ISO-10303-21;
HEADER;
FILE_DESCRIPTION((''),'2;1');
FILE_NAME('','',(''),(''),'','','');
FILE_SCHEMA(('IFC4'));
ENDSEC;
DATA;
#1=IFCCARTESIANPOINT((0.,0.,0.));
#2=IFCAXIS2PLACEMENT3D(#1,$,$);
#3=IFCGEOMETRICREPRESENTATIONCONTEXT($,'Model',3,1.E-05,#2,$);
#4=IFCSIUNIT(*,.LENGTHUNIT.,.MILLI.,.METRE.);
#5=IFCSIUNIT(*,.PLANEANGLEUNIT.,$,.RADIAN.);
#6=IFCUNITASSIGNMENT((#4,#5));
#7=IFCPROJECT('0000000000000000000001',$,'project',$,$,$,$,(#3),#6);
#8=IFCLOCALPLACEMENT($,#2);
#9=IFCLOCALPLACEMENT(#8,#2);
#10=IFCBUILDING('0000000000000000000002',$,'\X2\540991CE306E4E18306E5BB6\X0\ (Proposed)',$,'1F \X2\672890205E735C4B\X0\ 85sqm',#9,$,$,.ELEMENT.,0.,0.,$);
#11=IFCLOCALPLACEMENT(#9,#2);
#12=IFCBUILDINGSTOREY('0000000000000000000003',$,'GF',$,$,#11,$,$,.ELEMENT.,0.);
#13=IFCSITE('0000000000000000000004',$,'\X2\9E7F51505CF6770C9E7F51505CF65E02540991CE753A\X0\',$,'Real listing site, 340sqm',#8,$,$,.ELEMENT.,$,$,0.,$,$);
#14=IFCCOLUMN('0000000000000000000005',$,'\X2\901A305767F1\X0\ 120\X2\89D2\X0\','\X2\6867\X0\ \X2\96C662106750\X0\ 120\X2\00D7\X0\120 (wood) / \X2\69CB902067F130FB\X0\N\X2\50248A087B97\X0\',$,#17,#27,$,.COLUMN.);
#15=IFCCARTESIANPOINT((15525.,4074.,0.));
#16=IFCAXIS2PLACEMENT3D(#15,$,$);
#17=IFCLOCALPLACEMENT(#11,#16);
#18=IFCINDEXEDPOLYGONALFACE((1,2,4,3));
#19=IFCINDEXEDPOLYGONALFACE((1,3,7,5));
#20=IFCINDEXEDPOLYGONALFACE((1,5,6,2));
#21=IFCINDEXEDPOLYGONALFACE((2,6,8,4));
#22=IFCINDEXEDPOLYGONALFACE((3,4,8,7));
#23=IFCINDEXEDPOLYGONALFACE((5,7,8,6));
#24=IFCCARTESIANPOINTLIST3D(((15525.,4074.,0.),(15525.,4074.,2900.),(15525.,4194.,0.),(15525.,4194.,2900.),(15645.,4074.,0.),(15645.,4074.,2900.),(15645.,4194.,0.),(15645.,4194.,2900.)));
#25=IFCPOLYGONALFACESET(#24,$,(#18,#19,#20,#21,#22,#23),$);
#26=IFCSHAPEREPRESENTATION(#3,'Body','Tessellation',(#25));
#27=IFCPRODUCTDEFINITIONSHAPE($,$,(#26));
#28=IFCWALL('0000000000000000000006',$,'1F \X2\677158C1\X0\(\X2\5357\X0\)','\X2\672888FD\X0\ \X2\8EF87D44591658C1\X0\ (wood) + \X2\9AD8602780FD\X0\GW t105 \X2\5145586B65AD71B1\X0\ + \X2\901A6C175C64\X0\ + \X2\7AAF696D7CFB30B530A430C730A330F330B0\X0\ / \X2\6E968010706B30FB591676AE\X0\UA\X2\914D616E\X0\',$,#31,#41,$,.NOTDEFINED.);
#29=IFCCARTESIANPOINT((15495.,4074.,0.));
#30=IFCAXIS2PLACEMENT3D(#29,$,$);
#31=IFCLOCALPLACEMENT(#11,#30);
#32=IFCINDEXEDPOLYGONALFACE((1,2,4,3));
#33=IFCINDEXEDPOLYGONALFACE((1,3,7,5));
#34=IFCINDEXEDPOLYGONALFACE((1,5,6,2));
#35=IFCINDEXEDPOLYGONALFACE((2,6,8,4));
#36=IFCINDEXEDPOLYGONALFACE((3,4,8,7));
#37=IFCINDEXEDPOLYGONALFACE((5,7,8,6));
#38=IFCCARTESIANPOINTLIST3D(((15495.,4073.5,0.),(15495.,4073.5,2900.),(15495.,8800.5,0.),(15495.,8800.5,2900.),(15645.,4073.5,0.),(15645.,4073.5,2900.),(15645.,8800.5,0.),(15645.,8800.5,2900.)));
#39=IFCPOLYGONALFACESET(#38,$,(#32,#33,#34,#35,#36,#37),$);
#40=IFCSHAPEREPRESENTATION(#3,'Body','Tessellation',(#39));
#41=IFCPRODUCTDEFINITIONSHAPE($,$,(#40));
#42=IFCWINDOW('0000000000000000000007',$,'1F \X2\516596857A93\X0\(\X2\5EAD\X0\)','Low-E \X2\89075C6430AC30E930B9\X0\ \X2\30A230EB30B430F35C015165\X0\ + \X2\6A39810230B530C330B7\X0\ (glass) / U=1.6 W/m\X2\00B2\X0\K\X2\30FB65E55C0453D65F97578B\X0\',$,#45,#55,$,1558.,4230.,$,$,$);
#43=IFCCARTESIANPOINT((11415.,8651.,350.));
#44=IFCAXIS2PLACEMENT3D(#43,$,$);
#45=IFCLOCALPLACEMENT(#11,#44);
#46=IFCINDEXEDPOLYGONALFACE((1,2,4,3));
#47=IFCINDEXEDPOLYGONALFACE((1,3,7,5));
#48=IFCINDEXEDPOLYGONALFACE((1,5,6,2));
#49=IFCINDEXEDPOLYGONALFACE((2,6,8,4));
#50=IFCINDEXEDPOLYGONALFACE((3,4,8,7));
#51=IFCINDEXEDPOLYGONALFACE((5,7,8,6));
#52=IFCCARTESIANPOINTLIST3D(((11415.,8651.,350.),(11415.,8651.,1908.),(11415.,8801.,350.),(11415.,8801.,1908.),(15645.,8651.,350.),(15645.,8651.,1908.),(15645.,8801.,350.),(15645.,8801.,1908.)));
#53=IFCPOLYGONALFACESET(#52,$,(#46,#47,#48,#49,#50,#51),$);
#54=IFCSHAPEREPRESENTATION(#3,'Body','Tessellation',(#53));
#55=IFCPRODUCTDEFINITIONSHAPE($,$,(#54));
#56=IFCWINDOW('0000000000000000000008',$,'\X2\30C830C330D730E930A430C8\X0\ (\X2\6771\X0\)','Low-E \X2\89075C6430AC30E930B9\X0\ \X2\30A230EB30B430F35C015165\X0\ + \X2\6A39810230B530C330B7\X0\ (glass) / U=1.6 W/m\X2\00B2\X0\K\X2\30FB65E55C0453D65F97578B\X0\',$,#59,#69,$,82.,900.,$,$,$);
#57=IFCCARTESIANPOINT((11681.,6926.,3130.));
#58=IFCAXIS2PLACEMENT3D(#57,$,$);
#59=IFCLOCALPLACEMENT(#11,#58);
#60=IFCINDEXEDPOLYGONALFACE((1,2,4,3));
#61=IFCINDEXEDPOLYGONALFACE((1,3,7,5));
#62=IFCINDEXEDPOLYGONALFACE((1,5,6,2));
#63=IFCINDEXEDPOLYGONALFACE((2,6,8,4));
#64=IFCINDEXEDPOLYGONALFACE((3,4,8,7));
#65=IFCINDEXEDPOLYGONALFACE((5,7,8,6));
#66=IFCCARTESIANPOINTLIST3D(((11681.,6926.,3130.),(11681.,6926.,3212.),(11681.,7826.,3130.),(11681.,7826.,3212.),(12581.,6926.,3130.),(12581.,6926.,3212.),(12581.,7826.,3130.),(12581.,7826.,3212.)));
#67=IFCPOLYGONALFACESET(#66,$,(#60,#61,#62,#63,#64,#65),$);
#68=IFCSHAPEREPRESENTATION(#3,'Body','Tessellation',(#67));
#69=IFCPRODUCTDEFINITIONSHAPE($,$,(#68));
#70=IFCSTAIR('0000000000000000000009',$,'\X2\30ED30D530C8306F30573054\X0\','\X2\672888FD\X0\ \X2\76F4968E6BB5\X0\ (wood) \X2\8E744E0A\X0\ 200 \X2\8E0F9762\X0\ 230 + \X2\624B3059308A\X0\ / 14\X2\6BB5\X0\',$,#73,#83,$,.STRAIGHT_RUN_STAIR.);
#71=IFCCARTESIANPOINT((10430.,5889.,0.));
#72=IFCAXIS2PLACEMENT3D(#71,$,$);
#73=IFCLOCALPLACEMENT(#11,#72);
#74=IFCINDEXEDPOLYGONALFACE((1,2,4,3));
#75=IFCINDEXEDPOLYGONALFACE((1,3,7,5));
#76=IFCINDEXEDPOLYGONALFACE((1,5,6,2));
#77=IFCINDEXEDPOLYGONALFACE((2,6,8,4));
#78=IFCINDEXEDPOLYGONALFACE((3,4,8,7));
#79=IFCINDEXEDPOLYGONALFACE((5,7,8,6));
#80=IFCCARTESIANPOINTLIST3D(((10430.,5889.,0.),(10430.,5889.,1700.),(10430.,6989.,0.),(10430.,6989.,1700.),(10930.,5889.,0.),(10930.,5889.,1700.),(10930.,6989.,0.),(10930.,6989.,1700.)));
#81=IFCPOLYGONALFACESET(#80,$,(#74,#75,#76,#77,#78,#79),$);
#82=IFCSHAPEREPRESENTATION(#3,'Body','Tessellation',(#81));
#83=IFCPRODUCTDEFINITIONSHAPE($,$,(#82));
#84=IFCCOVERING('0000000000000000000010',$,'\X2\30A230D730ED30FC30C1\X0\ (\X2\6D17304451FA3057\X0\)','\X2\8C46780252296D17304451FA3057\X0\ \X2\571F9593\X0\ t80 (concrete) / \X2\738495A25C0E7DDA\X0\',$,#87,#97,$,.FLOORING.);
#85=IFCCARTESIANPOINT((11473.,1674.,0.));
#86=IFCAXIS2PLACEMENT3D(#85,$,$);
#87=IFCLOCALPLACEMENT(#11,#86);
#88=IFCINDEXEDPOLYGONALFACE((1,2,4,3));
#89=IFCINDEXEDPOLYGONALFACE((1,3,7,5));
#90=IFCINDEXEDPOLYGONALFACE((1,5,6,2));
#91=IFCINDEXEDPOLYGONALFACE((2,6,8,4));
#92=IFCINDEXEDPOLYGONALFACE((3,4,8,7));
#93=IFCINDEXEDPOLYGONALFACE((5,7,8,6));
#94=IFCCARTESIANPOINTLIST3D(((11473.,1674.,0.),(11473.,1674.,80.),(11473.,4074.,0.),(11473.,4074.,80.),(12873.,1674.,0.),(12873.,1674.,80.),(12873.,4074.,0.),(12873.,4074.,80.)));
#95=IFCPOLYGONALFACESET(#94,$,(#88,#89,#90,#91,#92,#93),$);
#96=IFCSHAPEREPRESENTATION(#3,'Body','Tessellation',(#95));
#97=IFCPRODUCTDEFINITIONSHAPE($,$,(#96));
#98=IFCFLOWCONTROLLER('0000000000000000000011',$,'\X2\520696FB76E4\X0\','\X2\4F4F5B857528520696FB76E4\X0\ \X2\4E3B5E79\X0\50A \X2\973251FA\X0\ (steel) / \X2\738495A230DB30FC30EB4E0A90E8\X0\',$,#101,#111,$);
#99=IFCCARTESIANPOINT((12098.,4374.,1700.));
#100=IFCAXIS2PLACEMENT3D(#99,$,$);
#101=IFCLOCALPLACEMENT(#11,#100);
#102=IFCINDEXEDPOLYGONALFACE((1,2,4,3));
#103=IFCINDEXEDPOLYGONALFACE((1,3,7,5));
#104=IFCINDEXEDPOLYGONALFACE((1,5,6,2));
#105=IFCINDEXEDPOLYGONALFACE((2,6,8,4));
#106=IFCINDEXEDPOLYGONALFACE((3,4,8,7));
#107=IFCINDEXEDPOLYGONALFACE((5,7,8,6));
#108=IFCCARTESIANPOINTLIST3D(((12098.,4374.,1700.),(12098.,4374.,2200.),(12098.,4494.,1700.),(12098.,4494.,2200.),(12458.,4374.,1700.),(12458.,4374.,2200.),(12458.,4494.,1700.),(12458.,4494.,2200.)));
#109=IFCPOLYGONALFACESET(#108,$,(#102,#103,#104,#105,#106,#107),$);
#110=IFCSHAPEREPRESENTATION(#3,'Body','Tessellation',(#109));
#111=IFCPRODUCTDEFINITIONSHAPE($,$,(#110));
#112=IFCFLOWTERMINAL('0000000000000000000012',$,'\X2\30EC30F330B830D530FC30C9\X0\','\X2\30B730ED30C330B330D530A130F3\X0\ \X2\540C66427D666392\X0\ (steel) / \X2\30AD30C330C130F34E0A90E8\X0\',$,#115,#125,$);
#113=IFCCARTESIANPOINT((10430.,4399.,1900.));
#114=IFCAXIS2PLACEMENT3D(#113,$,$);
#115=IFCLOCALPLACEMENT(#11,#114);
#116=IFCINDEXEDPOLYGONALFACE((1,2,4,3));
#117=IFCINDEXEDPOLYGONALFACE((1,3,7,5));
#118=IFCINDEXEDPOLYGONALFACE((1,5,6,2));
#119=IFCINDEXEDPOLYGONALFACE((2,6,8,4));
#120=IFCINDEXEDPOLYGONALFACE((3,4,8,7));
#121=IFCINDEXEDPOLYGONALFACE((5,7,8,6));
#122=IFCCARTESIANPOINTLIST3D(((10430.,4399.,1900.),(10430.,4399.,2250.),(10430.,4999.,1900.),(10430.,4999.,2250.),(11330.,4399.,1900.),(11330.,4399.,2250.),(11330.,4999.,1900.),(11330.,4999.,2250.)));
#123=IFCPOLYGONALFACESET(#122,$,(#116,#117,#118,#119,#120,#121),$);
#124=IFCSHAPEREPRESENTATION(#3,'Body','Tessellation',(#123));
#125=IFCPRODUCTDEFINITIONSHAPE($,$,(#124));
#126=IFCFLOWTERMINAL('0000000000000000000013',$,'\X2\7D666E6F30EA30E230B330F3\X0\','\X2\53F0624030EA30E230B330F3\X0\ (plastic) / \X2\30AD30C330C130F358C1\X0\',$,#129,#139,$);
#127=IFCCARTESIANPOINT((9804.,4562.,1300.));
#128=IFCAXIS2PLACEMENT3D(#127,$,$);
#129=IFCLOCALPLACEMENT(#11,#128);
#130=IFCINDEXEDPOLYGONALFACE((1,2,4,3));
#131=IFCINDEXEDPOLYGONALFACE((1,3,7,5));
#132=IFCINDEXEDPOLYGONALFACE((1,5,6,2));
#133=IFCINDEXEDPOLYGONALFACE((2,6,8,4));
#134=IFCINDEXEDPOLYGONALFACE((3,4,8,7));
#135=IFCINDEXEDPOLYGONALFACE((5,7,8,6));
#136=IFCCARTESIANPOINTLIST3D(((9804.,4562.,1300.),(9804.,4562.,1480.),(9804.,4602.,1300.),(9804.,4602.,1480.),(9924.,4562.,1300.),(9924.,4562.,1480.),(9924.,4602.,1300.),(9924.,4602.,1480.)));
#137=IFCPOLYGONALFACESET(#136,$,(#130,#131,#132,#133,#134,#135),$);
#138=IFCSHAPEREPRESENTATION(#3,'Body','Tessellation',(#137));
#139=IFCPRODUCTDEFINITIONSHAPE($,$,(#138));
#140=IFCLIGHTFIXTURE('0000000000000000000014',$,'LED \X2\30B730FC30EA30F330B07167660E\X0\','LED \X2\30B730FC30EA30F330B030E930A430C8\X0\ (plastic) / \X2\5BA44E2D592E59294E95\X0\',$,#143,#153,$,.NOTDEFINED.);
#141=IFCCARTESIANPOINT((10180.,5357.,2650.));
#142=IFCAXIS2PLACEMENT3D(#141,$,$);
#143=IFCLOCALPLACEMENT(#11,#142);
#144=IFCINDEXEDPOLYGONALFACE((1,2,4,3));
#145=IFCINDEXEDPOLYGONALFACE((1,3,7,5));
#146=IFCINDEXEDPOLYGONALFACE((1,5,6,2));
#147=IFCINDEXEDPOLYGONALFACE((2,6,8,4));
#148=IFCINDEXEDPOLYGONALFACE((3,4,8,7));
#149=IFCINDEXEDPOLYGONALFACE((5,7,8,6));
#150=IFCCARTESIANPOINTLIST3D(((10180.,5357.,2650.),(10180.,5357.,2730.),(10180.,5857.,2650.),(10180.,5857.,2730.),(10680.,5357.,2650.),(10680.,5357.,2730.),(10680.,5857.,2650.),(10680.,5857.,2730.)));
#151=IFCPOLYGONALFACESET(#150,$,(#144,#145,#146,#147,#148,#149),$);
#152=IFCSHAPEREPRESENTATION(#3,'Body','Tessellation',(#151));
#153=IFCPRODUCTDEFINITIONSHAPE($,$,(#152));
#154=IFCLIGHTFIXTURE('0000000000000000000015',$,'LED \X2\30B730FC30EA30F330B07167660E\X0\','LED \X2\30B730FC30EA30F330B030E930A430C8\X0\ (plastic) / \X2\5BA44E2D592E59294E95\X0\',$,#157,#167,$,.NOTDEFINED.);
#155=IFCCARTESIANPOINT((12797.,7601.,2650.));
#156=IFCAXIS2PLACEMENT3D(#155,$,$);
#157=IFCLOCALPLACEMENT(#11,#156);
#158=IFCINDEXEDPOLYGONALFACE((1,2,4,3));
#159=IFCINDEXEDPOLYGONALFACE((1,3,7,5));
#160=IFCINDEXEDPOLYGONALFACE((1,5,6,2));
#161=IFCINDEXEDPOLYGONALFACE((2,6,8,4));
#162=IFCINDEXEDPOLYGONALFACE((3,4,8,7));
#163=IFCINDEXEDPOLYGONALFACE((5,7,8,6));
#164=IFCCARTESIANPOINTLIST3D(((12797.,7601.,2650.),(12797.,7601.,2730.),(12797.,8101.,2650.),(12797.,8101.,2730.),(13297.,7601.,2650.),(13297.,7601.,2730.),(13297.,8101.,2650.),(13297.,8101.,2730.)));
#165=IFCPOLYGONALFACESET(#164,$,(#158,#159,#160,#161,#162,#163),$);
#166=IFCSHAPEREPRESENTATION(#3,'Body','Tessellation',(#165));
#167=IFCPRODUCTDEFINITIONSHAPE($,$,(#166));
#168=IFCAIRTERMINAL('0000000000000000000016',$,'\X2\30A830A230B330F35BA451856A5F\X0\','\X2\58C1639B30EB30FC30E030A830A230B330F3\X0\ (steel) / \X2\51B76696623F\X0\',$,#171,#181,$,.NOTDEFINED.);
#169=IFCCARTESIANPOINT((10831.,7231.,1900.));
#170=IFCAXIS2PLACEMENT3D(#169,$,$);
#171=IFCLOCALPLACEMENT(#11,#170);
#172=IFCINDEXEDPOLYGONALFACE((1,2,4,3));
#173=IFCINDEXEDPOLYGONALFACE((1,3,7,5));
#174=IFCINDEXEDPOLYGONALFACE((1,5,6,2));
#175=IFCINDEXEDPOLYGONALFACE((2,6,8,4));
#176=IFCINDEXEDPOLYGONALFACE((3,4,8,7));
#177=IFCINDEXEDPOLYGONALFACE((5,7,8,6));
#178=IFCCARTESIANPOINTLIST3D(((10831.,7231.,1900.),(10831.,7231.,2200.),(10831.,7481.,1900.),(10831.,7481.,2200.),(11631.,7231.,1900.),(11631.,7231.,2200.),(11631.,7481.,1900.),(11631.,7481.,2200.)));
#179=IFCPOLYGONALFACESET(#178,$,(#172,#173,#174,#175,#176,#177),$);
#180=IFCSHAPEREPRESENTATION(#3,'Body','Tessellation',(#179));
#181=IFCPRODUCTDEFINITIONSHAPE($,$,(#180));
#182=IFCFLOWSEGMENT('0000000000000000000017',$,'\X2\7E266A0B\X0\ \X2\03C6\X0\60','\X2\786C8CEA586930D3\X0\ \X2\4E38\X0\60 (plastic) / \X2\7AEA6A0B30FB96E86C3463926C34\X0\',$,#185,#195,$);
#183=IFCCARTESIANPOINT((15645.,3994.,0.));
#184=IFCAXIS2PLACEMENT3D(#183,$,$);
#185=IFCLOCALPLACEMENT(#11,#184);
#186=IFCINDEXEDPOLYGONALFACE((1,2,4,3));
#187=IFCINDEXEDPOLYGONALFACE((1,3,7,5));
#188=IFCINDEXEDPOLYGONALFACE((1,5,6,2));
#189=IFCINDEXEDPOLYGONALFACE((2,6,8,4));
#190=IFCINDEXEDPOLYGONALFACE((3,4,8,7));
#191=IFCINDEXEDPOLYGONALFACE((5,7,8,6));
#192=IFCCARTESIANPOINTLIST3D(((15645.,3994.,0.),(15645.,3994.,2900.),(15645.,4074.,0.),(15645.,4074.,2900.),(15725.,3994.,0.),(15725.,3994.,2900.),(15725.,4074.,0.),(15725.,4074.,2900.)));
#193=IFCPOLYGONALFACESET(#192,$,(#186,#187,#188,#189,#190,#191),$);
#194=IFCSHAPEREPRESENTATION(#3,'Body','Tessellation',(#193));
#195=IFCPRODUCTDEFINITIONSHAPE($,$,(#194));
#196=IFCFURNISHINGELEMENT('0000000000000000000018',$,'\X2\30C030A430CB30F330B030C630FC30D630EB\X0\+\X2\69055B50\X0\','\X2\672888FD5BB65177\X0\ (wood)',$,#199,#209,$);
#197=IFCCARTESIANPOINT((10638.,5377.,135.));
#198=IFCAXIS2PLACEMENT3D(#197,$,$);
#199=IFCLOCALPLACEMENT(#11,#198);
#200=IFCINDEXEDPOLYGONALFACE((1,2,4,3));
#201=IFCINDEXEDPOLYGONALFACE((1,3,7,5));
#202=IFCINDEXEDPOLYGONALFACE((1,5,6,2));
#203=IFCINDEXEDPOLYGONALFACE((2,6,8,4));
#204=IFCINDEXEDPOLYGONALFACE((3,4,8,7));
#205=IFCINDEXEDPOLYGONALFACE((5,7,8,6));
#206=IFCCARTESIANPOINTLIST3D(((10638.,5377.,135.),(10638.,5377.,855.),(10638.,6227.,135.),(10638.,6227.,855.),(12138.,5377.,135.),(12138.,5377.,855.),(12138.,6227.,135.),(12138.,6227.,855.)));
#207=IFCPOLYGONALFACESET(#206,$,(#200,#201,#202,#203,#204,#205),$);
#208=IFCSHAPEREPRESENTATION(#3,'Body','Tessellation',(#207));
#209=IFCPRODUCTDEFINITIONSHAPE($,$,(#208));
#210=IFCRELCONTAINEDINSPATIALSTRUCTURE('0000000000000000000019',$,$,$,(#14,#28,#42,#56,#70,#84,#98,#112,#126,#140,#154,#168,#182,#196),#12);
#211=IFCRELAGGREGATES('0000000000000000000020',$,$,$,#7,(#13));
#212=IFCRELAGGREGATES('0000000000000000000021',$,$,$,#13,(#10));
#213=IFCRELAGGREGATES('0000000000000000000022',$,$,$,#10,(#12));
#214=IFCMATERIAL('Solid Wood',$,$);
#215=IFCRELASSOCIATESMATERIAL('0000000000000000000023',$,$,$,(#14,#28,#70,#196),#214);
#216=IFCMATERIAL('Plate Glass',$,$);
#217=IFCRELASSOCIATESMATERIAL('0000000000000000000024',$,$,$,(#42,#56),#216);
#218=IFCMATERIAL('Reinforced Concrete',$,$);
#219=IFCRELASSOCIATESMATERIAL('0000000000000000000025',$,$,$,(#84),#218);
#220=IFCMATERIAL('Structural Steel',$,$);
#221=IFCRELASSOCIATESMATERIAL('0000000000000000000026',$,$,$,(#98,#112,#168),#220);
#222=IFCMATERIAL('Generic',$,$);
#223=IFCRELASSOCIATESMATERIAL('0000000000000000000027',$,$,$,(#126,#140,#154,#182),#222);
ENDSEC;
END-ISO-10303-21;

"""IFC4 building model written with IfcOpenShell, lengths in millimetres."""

from ifc_helpers import new_model, si_unit, frame, frame_2d, origin, place, context, project, spatial, rectangle, extrude, material, element, fill, save


model = new_model("IFC4")

# Units and contexts
model_context = context("Model", 3, precision=1e-05, world=origin())
ifc_project = project(units=[si_unit("LENGTHUNIT", "METRE", prefix="MILLI"), si_unit("PLANEANGLEUNIT", "RADIAN")], contexts=[model_context])

# Site, building, storey
site_placement = place(None, origin())
site = spatial("IfcSite", under=ifc_project, at=site_placement, Name="鹿児島県鹿児島市吉野町", ObjectType="Real listing site, 340sqm", CompositionType="ELEMENT", RefElevation=0.0)
building_placement = place(site_placement, origin())
building = spatial("IfcBuilding", under=site, at=building_placement, Name="吉野の丘の家 (Proposed)", ObjectType="1F 木造平屋 85sqm", CompositionType="ELEMENT", ElevationOfRefHeight=0.0, ElevationOfTerrain=0.0)
storey_placement = place(building_placement, origin())
storey = spatial("IfcBuildingStorey", under=building, at=storey_placement, Name="GF", CompositionType="ELEMENT", Elevation=0.0)

# Column
ifc_material_1 = material(Name="Solid Wood")
column_1_placement = place(storey_placement, frame((15525.0, 4074.0, 0.0)))
element("IfcColumn", 1, at=column_1_placement, inside=storey, material=ifc_material_1, Name="通し柱 120角", Description="桧 集成材 120×120 (wood) / 構造柱・N値計算", PredefinedType="COLUMN", context=model_context, shape_type="SweptSolid", body=[
    extrude(rectangle(XDim=120.0, YDim=120.0, at=frame_2d((60.0, 60.0))), frame((15525.0, 4074.0, 0.0)), (0.0, 0.0, 1.0), 2900.0),
])

# Wall, opening, window
wall_1_placement = place(storey_placement, frame((15495.0, 4074.0, 0.0)))
wall_1 = element("IfcWall", 2, at=wall_1_placement, inside=storey, material=ifc_material_1, Name="1F 東壁(南)", Description="木製 軸組外壁 (wood) + 高性能GW t105 充填断熱 + 通気層 + 窯業系サイディング / 準耐火・外皮UA配慮", PredefinedType="NOTDEFINED", context=model_context, shape_type="SweptSolid", body=[
    extrude(rectangle(XDim=150.0, YDim=4727.0, at=frame_2d((75.0, 2363.0))), frame((15495.0, 4074.0, 0.0)), (0.0, 0.0, 1.0), 2900.0),
])
opening_1_placement = place(storey_placement, frame((11415.0, 8651.0, 350.0)))
opening_1 = element("IfcOpeningElement", 3, at=opening_1_placement, cuts=wall_1, PredefinedType="NOTDEFINED", context=model_context, shape_type="SweptSolid", body=[
    extrude(rectangle(XDim=4230.0, YDim=150.0, at=frame_2d((2115.0, 75.0))), frame((11415.0, 8651.0, 350.0)), (0.0, 0.0, 1.0), 1558.0),
])
ifc_material_2 = material(Name="Plate Glass")
window_1_placement = place(storey_placement, frame((11415.0, 8651.0, 350.0)))
window_1 = element("IfcWindow", 4, at=window_1_placement, inside=storey, material=ifc_material_2, Name="1F 入隅窓(庭)", Description="Low-E 複層ガラス アルゴン封入 + 樹脂サッシ (glass) / U=1.6 W/m²K・日射取得型", OverallHeight=1558.0, OverallWidth=4230.0, context=model_context, shape_type="SweptSolid", body=[
    extrude(rectangle(XDim=4230.0, YDim=150.0, at=frame_2d((2115.0, 75.0))), frame((11415.0, 8651.0, 350.0)), (0.0, 0.0, 1.0), 1558.0),
])
fill(opening_1, window_1)

# Window
window_2_placement = place(storey_placement, frame((11681.0, 6926.0, 3130.0)))
element("IfcWindow", 5, at=window_2_placement, inside=storey, material=ifc_material_2, Name="トップライト (東)", Description="Low-E 複層ガラス アルゴン封入 + 樹脂サッシ (glass) / U=1.6 W/m²K・日射取得型", OverallHeight=82.0, OverallWidth=900.0, context=model_context, shape_type="SweptSolid", body=[
    extrude(rectangle(XDim=900.0, YDim=900.0, at=frame_2d((450.0, 450.0))), frame((11681.0, 6926.0, 3130.0)), (0.0, 0.0, 1.0), 82.0),
])

# Stair
stair_placement = place(storey_placement, frame((10430.0, 5889.0, 0.0)))
element("IfcStair", 6, at=stair_placement, inside=storey, material=ifc_material_1, Name="ロフトはしご", Description="木製 直階段 (wood) 蹴上 200 踏面 230 + 手すり / 14段", PredefinedType="STRAIGHT_RUN_STAIR", context=model_context, shape_type="SweptSolid", body=[
    extrude(rectangle(XDim=500.0, YDim=1100.0, at=frame_2d((250.0, 550.0))), frame((10430.0, 5889.0, 0.0)), (0.0, 0.0, 1.0), 1700.0),
])

# Covering
ifc_material_3 = material(Name="Reinforced Concrete")
covering_placement = place(storey_placement, frame((11473.0, 1674.0, 0.0)))
element("IfcCovering", 7, at=covering_placement, inside=storey, material=ifc_material_3, Name="アプローチ (洗い出し)", Description="豆砂利洗い出し 土間 t80 (concrete) / 玄関導線", PredefinedType="FLOORING", context=model_context, shape_type="SweptSolid", body=[
    extrude(rectangle(XDim=1400.0, YDim=2400.0, at=frame_2d((700.0, 1200.0))), frame((11473.0, 1674.0, 0.0)), (0.0, 0.0, 1.0), 80.0),
])

# Flow controller
ifc_material_4 = material(Name="Structural Steel")
flow_controller_placement = place(storey_placement, frame((12098.0, 4374.0, 1700.0)))
element("IfcFlowController", 8, at=flow_controller_placement, inside=storey, material=ifc_material_4, Name="分電盤", Description="住宅用分電盤 主幹50A 露出 (steel) / 玄関ホール上部", context=model_context, shape_type="SweptSolid", body=[
    extrude(rectangle(XDim=360.0, YDim=120.0, at=frame_2d((180.0, 60.0))), frame((12098.0, 4374.0, 1700.0)), (0.0, 0.0, 1.0), 500.0),
])

# Flow terminals
flow_terminal_1_placement = place(storey_placement, frame((10430.0, 4399.0, 1900.0)))
element("IfcFlowTerminal", 9, at=flow_terminal_1_placement, inside=storey, material=ifc_material_4, Name="レンジフード", Description="シロッコファン 同時給排 (steel) / キッチン上部", context=model_context, shape_type="SweptSolid", body=[
    extrude(rectangle(XDim=900.0, YDim=600.0, at=frame_2d((450.0, 300.0))), frame((10430.0, 4399.0, 1900.0)), (0.0, 0.0, 1.0), 350.0),
])
ifc_material_5 = material(Name="Generic")
flow_terminal_2_placement = place(storey_placement, frame((9804.0, 4562.0, 1300.0)))
element("IfcFlowTerminal", 10, at=flow_terminal_2_placement, inside=storey, material=ifc_material_5, Name="給湯リモコン", Description="台所リモコン (plastic) / キッチン壁", context=model_context, shape_type="SweptSolid", body=[
    extrude(rectangle(XDim=120.0, YDim=40.0, at=frame_2d((60.0, 20.0))), frame((9804.0, 4562.0, 1300.0)), (0.0, 0.0, 1.0), 180.0),
])

# Light fixtures
light_fixture_1_placement = place(storey_placement, frame((10180.0, 5357.0, 2650.0)))
element("IfcLightFixture", 11, at=light_fixture_1_placement, inside=storey, material=ifc_material_5, Name="LED シーリング照明", Description="LED シーリングライト (plastic) / 室中央天井", PredefinedType="NOTDEFINED", context=model_context, shape_type="SweptSolid", body=[
    extrude(rectangle(XDim=500.0, YDim=500.0, at=frame_2d((250.0, 250.0))), frame((10180.0, 5357.0, 2650.0)), (0.0, 0.0, 1.0), 80.0),
])
light_fixture_2_placement = place(storey_placement, frame((12797.0, 7601.0, 2650.0)))
element("IfcLightFixture", 12, at=light_fixture_2_placement, inside=storey, material=ifc_material_5, Name="LED シーリング照明", Description="LED シーリングライト (plastic) / 室中央天井", PredefinedType="NOTDEFINED", context=model_context, shape_type="SweptSolid", body=[
    extrude(rectangle(XDim=500.0, YDim=500.0, at=frame_2d((250.0, 250.0))), frame((12797.0, 7601.0, 2650.0)), (0.0, 0.0, 1.0), 80.0),
])

# Air terminal
air_terminal_placement = place(storey_placement, frame((10831.0, 7231.0, 1900.0)))
element("IfcAirTerminal", 13, at=air_terminal_placement, inside=storey, material=ifc_material_4, Name="エアコン室内機", Description="壁掛ルームエアコン (steel) / 冷暖房", PredefinedType="NOTDEFINED", context=model_context, shape_type="SweptSolid", body=[
    extrude(rectangle(XDim=800.0, YDim=250.0, at=frame_2d((400.0, 125.0))), frame((10831.0, 7231.0, 1900.0)), (0.0, 0.0, 1.0), 300.0),
])

# Flow segment
flow_segment_placement = place(storey_placement, frame((15645.0, 3994.0, 0.0)))
element("IfcFlowSegment", 14, at=flow_segment_placement, inside=storey, material=ifc_material_5, Name="縦樋 φ60", Description="硬質塩ビ 丸60 (plastic) / 竪樋・雨水排水", context=model_context, shape_type="SweptSolid", body=[
    extrude(rectangle(XDim=80.0, YDim=80.0, at=frame_2d((40.0, 40.0))), frame((15645.0, 3994.0, 0.0)), (0.0, 0.0, 1.0), 2900.0),
])

# Furnishing element
furnishing_1_placement = place(storey_placement, frame((10638.0, 5377.0, 135.0)))
element("IfcFurnishingElement", 15, at=furnishing_1_placement, inside=storey, material=ifc_material_1, Name="ダイニングテーブル+椅子", Description="木製家具 (wood)", context=model_context, shape_type="SweptSolid", body=[
    extrude(rectangle(XDim=1500.0, YDim=850.0, at=frame_2d((750.0, 425.0))), frame((10638.0, 5377.0, 135.0)), (0.0, 0.0, 1.0), 720.0),
])

save(model, "model.ifc")
